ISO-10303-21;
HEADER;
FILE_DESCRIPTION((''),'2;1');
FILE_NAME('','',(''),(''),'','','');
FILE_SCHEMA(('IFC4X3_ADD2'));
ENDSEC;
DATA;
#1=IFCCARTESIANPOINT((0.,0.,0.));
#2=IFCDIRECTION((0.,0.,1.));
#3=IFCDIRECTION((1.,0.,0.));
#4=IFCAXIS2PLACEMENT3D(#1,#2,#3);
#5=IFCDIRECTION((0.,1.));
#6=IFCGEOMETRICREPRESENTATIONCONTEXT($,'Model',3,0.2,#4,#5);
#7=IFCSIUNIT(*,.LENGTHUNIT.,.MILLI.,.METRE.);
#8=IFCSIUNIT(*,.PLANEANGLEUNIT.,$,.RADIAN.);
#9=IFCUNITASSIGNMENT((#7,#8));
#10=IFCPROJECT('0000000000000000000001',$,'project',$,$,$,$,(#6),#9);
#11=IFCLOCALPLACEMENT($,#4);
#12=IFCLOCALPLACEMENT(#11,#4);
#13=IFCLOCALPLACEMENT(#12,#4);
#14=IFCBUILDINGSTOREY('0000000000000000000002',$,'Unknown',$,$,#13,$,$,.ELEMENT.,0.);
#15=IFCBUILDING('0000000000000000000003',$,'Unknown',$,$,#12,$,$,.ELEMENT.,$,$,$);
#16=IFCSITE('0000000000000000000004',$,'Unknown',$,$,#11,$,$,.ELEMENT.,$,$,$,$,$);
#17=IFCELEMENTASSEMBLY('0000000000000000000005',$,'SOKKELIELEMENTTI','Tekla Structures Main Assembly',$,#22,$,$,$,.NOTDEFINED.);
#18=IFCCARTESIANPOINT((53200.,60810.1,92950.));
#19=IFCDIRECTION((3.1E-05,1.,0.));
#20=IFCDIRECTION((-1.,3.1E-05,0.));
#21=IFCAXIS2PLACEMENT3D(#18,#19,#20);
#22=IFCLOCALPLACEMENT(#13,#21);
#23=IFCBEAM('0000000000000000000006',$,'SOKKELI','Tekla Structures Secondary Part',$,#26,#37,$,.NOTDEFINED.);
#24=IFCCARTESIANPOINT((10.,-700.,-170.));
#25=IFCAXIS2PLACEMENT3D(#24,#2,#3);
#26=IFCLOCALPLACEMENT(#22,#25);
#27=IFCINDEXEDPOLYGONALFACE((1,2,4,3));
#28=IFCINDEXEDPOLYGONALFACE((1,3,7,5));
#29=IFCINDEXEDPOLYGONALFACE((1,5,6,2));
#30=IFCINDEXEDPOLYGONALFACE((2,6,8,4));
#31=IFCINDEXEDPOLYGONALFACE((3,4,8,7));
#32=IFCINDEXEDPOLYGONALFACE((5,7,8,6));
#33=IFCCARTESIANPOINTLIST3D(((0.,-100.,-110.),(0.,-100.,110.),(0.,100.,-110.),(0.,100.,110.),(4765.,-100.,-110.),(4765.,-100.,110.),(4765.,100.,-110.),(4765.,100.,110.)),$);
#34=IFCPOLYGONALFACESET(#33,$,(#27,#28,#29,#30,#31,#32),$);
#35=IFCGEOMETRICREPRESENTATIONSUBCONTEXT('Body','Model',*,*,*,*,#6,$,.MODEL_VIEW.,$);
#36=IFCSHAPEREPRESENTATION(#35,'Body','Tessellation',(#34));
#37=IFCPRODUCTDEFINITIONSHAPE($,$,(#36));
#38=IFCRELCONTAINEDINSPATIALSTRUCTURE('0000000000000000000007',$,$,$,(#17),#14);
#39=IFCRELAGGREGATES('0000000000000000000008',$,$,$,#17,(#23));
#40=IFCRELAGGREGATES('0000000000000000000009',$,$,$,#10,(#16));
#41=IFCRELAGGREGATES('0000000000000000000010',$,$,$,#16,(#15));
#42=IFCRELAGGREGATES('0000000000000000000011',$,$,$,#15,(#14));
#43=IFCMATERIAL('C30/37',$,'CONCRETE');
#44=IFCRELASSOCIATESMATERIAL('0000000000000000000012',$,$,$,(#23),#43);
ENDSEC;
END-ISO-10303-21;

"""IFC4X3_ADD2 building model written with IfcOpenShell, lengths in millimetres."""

from ifc_helpers import new_model, si_unit, direction, frame, origin_with_axes, place, context, subcontext, project, spatial, line, indexed_curve, outline, extrude, material, element, aggregate, save


model = new_model("IFC4X3_ADD2")

# Units and contexts
model_context = context("Model", 3, precision=0.2, world=origin_with_axes(), true_north=direction((0.0, 1.0)))
body_context = subcontext(model_context, "Body", "Model", "MODEL_VIEW")
ifc_project = project(units=[si_unit("LENGTHUNIT", "METRE", prefix="MILLI"), si_unit("PLANEANGLEUNIT", "RADIAN")], contexts=[model_context])

# Site, building, storey
site_placement = place(None, origin_with_axes())
site = spatial("IfcSite", under=ifc_project, at=site_placement, Name="Unknown", CompositionType="ELEMENT")
building_placement = place(site_placement, origin_with_axes())
building = spatial("IfcBuilding", under=site, at=building_placement, Name="Unknown", CompositionType="ELEMENT")
storey_placement = place(building_placement, origin_with_axes())
storey = spatial("IfcBuildingStorey", under=building, at=storey_placement, Name="Unknown", CompositionType="ELEMENT", Elevation=0.0)

# Shared definitions
ifc_material_1 = material(Name="C30/37", Category="CONCRETE")

# Element assembly, beam
assembly_1_placement = place(storey_placement, frame((53200.0, 60810.1, 92950.0), z_axis=(0.000031, 1.0, 0.0), x_axis=(-1.0, 0.000031, 0.0)))
assembly_1 = element("IfcElementAssembly", 1, at=assembly_1_placement, inside=storey, Name="SOKKELIELEMENTTI", Description="Tekla Structures Main Assembly", PredefinedType="NOTDEFINED")
beam_1_placement = place(assembly_1_placement, frame((10.0, -700.0, -170.0), z_axis=(0.0, 0.0, 1.0), x_axis=(1.0, 0.0, 0.0)))
beam_1 = element("IfcBeam", 2, at=beam_1_placement, material=ifc_material_1, Name="SOKKELI", Description="Tekla Structures Secondary Part", PredefinedType="NOTDEFINED", context=body_context, shape_type="SolidModel", body=[
    extrude(outline(indexed_curve([(-110.0, -100.0), (110.0, -100.0), (110.0, 100.0), (-110.0, 100.0)], segments=[line(1, 2, 3, 4, 1)])), frame((0.0, 0.0, 0.0), z_axis=(-1.0, 0.0, 0.0), x_axis=(0.0, 0.0, 1.0)), (0.0, 0.0, -1.0), 4765.0),
])
aggregate(assembly_1, [beam_1])

save(model, "model.ifc")
